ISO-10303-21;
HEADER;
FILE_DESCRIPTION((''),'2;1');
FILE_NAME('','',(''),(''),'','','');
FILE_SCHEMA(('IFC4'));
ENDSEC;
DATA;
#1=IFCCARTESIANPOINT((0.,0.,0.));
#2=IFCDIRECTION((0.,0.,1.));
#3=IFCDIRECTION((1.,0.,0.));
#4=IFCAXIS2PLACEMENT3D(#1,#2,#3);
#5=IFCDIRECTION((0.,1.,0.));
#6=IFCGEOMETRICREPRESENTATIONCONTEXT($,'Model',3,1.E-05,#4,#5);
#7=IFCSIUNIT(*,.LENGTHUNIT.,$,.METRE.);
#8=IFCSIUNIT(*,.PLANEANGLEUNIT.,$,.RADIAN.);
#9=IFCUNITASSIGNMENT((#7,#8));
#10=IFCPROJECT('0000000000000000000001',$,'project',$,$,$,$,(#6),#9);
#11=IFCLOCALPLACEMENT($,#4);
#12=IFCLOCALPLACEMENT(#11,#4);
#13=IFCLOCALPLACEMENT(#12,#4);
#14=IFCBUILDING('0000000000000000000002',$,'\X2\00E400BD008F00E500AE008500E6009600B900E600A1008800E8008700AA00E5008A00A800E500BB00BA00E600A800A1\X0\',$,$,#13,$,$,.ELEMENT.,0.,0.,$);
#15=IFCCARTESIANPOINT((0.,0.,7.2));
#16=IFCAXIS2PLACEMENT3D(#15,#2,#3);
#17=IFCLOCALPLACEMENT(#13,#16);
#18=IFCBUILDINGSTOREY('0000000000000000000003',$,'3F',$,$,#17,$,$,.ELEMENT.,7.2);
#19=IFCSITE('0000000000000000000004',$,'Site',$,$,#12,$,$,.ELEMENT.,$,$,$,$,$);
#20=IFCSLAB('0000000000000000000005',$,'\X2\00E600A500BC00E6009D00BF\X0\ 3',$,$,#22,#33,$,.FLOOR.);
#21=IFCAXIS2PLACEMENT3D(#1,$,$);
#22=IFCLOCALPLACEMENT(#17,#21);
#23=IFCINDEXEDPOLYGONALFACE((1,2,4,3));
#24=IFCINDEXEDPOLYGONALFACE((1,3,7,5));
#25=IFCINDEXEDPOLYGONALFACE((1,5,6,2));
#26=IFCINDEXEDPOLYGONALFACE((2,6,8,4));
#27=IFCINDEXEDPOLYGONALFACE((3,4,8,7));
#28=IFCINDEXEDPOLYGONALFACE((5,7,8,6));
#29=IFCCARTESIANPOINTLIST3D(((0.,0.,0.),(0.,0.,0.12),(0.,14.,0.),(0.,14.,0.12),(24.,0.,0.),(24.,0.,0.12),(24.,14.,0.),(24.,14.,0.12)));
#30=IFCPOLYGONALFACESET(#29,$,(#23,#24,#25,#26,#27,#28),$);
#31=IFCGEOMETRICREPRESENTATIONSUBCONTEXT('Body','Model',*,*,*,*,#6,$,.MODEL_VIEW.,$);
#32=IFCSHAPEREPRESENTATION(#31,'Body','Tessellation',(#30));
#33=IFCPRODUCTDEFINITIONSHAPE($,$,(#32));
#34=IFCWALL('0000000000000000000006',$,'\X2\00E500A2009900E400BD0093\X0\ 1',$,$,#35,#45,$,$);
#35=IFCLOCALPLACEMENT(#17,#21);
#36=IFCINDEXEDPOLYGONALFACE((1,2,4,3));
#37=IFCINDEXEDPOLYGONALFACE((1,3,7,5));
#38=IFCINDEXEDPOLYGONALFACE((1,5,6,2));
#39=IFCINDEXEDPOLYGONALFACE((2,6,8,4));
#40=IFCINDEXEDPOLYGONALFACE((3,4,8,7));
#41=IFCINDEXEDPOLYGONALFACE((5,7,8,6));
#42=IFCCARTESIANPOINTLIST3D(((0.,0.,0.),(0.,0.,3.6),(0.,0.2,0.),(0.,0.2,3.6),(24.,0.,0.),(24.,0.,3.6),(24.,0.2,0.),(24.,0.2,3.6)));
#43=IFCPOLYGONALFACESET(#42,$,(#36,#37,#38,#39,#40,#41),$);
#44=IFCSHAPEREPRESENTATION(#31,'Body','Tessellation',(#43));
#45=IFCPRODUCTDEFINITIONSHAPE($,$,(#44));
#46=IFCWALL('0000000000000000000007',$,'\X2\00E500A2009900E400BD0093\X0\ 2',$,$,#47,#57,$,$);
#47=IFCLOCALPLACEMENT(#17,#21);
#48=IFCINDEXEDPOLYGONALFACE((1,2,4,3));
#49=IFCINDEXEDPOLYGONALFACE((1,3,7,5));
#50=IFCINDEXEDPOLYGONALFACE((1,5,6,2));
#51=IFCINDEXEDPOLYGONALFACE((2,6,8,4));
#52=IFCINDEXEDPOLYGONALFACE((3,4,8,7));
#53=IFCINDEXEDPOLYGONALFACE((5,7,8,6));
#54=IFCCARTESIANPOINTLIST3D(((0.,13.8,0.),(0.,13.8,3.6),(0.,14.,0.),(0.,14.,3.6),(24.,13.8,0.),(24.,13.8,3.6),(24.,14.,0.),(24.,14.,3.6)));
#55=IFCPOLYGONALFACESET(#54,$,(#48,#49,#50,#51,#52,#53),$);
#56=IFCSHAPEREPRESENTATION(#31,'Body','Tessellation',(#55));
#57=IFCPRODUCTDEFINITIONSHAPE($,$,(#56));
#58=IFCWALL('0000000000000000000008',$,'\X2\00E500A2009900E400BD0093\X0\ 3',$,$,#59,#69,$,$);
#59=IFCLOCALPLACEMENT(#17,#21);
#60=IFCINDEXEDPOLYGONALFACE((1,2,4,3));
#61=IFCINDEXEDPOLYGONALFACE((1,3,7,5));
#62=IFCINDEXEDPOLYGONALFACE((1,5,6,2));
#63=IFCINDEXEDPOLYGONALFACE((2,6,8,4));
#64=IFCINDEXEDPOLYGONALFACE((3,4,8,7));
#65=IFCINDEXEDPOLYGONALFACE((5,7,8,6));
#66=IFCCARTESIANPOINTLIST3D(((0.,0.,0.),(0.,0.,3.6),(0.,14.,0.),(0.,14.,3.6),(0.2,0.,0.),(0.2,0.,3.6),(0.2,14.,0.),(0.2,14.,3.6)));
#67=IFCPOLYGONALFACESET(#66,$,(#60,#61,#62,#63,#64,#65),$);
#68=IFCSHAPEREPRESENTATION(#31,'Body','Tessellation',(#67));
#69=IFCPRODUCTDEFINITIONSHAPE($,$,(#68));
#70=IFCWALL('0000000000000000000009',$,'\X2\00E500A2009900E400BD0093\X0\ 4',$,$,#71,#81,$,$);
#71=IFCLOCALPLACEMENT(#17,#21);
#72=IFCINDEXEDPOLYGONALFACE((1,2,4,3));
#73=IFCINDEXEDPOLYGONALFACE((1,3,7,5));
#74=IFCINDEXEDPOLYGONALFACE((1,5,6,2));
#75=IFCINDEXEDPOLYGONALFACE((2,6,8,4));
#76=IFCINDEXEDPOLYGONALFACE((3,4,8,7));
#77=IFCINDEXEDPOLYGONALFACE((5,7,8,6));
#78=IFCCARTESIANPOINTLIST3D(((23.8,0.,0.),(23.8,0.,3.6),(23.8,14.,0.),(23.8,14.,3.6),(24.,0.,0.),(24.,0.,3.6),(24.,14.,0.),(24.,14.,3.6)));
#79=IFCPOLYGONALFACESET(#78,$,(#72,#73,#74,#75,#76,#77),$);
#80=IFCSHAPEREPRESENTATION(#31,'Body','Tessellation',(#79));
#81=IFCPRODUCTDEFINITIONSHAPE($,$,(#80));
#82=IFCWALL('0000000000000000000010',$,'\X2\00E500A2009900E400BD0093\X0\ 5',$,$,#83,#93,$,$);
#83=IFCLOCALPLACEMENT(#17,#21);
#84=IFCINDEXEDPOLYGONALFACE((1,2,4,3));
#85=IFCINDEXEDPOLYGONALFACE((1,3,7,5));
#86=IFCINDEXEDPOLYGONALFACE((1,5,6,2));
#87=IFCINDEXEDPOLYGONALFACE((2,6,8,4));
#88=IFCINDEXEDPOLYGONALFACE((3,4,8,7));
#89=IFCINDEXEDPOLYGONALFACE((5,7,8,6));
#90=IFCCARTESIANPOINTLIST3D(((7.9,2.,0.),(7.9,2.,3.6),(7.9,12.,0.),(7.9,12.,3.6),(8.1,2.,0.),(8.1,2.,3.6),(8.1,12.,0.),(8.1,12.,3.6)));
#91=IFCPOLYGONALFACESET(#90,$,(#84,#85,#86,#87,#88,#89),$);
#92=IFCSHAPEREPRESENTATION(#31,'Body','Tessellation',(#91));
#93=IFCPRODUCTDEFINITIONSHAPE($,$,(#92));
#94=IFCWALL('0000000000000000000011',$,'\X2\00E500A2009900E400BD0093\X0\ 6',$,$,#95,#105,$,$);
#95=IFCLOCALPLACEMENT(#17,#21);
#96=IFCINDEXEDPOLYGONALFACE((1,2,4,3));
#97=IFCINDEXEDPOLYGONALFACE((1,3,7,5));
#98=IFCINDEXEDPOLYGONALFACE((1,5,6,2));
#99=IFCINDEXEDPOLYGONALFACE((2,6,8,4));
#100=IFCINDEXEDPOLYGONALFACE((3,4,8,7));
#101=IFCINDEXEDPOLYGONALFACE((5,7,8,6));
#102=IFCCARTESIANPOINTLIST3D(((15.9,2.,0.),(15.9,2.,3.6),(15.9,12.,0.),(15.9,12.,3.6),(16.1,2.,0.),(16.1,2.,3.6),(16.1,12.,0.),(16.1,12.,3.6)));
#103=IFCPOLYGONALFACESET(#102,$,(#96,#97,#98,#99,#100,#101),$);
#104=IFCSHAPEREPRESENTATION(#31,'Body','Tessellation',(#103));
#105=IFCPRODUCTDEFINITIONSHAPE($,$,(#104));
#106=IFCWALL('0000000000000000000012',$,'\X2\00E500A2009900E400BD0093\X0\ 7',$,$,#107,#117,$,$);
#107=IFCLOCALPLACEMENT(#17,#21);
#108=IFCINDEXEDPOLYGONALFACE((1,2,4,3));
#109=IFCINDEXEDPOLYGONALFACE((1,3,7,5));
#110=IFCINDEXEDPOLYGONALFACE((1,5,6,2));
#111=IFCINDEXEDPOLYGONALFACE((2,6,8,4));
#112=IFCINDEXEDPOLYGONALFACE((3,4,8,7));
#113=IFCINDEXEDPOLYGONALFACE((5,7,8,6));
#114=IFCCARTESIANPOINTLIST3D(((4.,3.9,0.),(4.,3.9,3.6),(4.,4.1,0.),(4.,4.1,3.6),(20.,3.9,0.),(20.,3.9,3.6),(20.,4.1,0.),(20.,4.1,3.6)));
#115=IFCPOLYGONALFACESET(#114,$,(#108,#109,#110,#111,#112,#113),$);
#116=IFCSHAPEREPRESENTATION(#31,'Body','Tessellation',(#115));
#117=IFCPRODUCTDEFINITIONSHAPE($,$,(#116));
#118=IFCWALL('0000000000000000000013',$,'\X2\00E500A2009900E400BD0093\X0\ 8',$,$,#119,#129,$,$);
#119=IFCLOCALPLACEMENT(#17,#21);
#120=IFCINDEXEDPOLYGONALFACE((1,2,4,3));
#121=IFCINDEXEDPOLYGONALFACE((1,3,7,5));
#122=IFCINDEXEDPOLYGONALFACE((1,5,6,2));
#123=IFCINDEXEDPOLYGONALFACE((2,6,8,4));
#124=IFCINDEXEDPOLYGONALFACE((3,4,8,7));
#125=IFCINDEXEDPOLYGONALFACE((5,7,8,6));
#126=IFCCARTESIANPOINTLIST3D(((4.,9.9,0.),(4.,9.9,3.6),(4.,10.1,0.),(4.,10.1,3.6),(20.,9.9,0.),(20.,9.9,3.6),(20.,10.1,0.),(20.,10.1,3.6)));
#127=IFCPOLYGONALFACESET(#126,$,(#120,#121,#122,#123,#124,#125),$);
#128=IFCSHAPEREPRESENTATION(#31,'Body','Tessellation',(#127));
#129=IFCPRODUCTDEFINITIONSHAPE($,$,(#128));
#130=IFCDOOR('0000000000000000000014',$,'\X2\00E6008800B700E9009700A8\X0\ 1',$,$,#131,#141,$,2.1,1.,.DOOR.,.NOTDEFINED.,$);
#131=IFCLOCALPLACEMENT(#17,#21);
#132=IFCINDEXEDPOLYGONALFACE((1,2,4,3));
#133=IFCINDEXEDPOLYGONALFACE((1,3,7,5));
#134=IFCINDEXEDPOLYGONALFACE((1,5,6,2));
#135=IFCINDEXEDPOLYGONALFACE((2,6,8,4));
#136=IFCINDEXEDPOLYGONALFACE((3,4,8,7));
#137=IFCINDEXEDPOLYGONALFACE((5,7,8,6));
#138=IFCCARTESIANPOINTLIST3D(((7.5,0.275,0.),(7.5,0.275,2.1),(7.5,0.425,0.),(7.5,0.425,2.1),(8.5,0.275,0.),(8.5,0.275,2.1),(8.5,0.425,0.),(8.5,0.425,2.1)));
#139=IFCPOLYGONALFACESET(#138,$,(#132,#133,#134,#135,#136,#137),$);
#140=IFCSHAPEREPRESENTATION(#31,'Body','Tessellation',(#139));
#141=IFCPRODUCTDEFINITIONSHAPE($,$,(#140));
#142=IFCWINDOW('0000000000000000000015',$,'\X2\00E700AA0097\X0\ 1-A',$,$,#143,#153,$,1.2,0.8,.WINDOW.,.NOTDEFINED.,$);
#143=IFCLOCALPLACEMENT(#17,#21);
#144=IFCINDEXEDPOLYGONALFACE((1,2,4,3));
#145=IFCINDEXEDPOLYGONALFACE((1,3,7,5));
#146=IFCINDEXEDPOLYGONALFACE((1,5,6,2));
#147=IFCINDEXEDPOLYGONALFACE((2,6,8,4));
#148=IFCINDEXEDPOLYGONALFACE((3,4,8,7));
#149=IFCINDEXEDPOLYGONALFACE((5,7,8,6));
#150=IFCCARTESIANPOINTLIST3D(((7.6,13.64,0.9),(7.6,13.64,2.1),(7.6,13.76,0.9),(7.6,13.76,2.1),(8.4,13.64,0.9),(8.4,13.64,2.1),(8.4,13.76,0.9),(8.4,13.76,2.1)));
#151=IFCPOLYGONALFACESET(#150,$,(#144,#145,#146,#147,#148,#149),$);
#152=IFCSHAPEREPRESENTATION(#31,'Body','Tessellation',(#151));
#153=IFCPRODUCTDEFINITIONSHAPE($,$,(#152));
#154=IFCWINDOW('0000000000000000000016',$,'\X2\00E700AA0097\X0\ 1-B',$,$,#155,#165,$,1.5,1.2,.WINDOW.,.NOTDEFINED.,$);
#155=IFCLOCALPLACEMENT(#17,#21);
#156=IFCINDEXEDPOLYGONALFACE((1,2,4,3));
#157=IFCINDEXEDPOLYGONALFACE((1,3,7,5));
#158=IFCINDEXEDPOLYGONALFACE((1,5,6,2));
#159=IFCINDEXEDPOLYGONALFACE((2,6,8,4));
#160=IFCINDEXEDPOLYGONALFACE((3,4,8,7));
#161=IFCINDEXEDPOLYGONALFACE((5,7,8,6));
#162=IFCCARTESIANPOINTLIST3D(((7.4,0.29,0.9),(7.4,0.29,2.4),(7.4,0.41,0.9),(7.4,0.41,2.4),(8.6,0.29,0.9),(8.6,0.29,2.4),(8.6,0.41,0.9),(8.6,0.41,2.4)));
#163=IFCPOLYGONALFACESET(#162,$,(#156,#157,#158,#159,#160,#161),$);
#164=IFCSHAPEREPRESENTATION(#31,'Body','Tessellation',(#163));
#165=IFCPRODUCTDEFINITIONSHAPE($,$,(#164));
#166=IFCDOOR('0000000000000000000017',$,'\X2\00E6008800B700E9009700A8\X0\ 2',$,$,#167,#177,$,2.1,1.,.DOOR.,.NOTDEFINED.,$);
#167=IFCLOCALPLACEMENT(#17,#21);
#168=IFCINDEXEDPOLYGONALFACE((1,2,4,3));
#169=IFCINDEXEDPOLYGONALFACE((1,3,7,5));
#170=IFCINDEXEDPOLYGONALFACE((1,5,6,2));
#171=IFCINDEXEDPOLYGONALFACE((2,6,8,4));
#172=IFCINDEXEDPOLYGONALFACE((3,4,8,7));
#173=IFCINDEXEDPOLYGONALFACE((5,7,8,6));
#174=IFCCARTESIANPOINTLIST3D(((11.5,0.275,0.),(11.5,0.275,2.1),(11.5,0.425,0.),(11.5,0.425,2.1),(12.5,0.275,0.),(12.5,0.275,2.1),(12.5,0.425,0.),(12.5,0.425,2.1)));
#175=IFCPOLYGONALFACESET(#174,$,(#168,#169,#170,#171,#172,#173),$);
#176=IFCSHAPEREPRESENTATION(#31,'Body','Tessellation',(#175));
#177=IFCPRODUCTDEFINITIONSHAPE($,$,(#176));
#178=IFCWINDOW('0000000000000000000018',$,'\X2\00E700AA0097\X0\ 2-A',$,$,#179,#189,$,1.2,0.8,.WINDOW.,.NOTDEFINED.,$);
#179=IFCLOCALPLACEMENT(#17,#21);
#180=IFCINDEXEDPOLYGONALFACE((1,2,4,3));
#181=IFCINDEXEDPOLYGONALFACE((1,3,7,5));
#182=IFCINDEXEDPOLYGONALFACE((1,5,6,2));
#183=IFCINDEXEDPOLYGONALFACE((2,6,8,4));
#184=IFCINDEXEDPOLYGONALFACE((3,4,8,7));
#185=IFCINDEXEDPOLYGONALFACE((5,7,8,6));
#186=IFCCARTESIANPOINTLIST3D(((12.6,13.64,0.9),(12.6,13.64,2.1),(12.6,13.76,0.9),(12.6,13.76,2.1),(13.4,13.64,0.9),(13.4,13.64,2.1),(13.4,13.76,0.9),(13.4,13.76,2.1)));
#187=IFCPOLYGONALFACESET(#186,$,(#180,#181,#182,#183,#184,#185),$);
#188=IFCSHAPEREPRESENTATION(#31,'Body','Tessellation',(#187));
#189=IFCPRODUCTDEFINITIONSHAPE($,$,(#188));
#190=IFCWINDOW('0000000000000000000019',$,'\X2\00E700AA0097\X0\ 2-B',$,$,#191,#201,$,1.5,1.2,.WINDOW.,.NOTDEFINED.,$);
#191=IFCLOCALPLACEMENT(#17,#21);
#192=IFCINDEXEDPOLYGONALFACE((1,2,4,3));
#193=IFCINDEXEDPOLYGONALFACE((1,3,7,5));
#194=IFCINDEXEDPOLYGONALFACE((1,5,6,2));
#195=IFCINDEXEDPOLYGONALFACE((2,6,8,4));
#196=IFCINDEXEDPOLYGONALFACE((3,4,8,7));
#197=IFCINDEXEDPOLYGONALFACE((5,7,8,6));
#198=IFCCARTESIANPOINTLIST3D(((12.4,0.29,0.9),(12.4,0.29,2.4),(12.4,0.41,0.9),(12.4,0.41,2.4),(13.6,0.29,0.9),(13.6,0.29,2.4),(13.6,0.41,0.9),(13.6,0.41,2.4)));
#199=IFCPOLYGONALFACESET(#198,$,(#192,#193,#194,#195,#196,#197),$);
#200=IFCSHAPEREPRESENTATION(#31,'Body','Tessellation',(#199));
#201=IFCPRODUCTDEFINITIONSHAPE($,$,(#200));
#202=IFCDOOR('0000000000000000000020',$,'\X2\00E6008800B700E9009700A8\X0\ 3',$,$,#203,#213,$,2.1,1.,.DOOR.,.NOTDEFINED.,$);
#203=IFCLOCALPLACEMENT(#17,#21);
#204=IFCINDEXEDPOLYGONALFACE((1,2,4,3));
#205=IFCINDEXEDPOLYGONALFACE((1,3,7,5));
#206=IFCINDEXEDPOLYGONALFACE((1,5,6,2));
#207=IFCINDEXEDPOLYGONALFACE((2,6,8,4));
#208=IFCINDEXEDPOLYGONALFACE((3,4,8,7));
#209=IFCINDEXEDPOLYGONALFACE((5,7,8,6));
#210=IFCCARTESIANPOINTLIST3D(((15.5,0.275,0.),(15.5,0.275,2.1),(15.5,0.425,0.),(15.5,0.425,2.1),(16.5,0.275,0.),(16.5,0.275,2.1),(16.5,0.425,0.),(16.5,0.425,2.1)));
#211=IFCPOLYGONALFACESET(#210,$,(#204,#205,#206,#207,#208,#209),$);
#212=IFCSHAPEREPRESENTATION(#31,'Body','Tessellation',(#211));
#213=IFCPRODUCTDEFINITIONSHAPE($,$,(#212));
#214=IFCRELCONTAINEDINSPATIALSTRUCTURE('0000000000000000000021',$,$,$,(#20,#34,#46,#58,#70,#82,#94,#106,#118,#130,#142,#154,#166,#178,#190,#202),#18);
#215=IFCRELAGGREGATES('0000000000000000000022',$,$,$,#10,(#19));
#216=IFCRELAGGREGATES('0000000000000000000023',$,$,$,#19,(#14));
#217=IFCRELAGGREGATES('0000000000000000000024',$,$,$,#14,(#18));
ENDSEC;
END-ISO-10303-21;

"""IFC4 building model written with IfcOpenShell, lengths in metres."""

from ifc_helpers import new_model, si_unit, direction, frame, frame_2d, origin_with_axes, place, context, subcontext, project, spatial, rectangle, extrude, element, save


model = new_model("IFC4")

# Units and contexts
model_context = context("Model", 3, precision=1e-05, world=origin_with_axes(), true_north=direction((0.0, 1.0, 0.0)))
body_context = subcontext(model_context, "Body", "Model", "MODEL_VIEW")
ifc_project = project(units=[si_unit("LENGTHUNIT", "METRE"), si_unit("PLANEANGLEUNIT", "RADIAN")], contexts=[model_context])

# Site, building, storey
placement = place(None, origin_with_axes())
site_placement = place(placement, origin_with_axes())
site = spatial("IfcSite", under=ifc_project, at=site_placement, Name="Site", CompositionType="ELEMENT")
building_placement = place(site_placement, origin_with_axes())
building = spatial("IfcBuilding", under=site, at=building_placement, Name="ä½\u008få®\u0085æ\u0096¹æ¡\u0088è\u0087ªå\u008a¨å»ºæ¨¡", CompositionType="ELEMENT", ElevationOfRefHeight=0.0, ElevationOfTerrain=0.0)
storey_placement = place(building_placement, frame((0.0, 0.0, 7.2), z_axis=(0.0, 0.0, 1.0), x_axis=(1.0, 0.0, 0.0)))
storey = spatial("IfcBuildingStorey", under=building, at=storey_placement, Name="3F", CompositionType="ELEMENT", Elevation=7.2)

# Slab
slab_placement = place(storey_placement, frame((12.0, 7.0, 0.0), z_axis=(0.0, 0.0, 1.0), x_axis=(1.0, 0.0, 0.0)))
element("IfcSlab", 1, at=slab_placement, inside=storey, Name="æ¥¼æ\u009d¿ 3", PredefinedType="FLOOR", context=body_context, shape_type="SweptSolid", body=[
    extrude(rectangle(XDim=24.0, YDim=14.0, at=frame_2d((0.0, 0.0), x_axis=(1.0, 0.0, 0.0))), frame((0.0, 0.0, 0.0), z_axis=(0.0, 0.0, 1.0)), (0.0, 0.0, 1.0), 0.12),
])

# Walls
for number, where, z_axis, x_axis, name in (
    (2, (12.0, 0.1, 0.0), (0.0, 0.0, 1.0), (1.0, 0.0, 0.0), "å¢\u0099ä½\u0093 1"),
    (3, (12.0, 13.9, 0.0), (0.0, 0.0, 1.0), (1.0, 0.0, 0.0), "å¢\u0099ä½\u0093 2"),
):
    element("IfcWall", number, at=place(storey_placement, frame(where, z_axis=z_axis, x_axis=x_axis)), inside=storey, Name=name, context=body_context, shape_type="SweptSolid", body=[
        extrude(rectangle(XDim=24.0, YDim=0.2, at=frame_2d((0.0, 0.0), x_axis=(1.0, 0.0, 0.0))), frame((0.0, 0.0, 0.0), z_axis=(0.0, 0.0, 1.0)), (0.0, 0.0, 1.0), 3.6),
    ])
for number, where, z_axis, x_axis, name in (
    (4, (0.1, 7.0, 0.0), (0.0, 0.0, 1.0), (0.0, 1.0, 0.0), "å¢\u0099ä½\u0093 3"),
    (5, (23.9, 7.0, 0.0), (0.0, 0.0, 1.0), (0.0, 1.0, 0.0), "å¢\u0099ä½\u0093 4"),
):
    element("IfcWall", number, at=place(storey_placement, frame(where, z_axis=z_axis, x_axis=x_axis)), inside=storey, Name=name, context=body_context, shape_type="SweptSolid", body=[
        extrude(rectangle(XDim=14.0, YDim=0.2, at=frame_2d((0.0, 0.0), x_axis=(1.0, 0.0, 0.0))), frame((0.0, 0.0, 0.0), z_axis=(0.0, 0.0, 1.0)), (0.0, 0.0, 1.0), 3.6),
    ])
for number, where, z_axis, x_axis, name in (
    (6, (8.0, 7.0, 0.0), (0.0, 0.0, 1.0), (0.0, 1.0, 0.0), "å¢\u0099ä½\u0093 5"),
    (7, (16.0, 7.0, 0.0), (0.0, 0.0, 1.0), (0.0, 1.0, 0.0), "å¢\u0099ä½\u0093 6"),
):
    element("IfcWall", number, at=place(storey_placement, frame(where, z_axis=z_axis, x_axis=x_axis)), inside=storey, Name=name, context=body_context, shape_type="SweptSolid", body=[
        extrude(rectangle(XDim=10.0, YDim=0.2, at=frame_2d((0.0, 0.0), x_axis=(1.0, 0.0, 0.0))), frame((0.0, 0.0, 0.0), z_axis=(0.0, 0.0, 1.0)), (0.0, 0.0, 1.0), 3.6),
    ])
for number, where, z_axis, x_axis, name in (
    (8, (12.0, 4.0, 0.0), (0.0, 0.0, 1.0), (1.0, 0.0, 0.0), "å¢\u0099ä½\u0093 7"),
    (9, (12.0, 10.0, 0.0), (0.0, 0.0, 1.0), (1.0, 0.0, 0.0), "å¢\u0099ä½\u0093 8"),
):
    element("IfcWall", number, at=place(storey_placement, frame(where, z_axis=z_axis, x_axis=x_axis)), inside=storey, Name=name, context=body_context, shape_type="SweptSolid", body=[
        extrude(rectangle(XDim=16.0, YDim=0.2, at=frame_2d((0.0, 0.0), x_axis=(1.0, 0.0, 0.0))), frame((0.0, 0.0, 0.0), z_axis=(0.0, 0.0, 1.0)), (0.0, 0.0, 1.0), 3.6),
    ])

# Door
door_1_placement = place(storey_placement, frame((8.0, 0.35, 0.0), z_axis=(0.0, 0.0, 1.0), x_axis=(1.0, 0.0, 0.0)))
element("IfcDoor", 10, at=door_1_placement, inside=storey, Name="æ\u0088·é\u0097¨ 1", OperationType="NOTDEFINED", OverallHeight=2.1, OverallWidth=1.0, PredefinedType="DOOR", context=body_context, shape_type="SweptSolid", body=[
    extrude(rectangle(XDim=1.0, YDim=0.15, at=frame_2d((0.0, 0.0), x_axis=(1.0, 0.0, 0.0))), frame((0.0, 0.0, 0.0), z_axis=(0.0, 0.0, 1.0)), (0.0, 0.0, 1.0), 2.1),
])

# Windows
window_1_placement = place(storey_placement, frame((8.0, 13.7, 0.9), z_axis=(0.0, 0.0, 1.0), x_axis=(1.0, 0.0, 0.0)))
element("IfcWindow", 11, at=window_1_placement, inside=storey, Name="çª\u0097 1-A", OverallHeight=1.2, OverallWidth=0.8, PartitioningType="NOTDEFINED", PredefinedType="WINDOW", context=body_context, shape_type="SweptSolid", body=[
    extrude(rectangle(XDim=0.8, YDim=0.12, at=frame_2d((0.0, 0.0), x_axis=(1.0, 0.0, 0.0))), frame((0.0, 0.0, 0.0), z_axis=(0.0, 0.0, 1.0)), (0.0, 0.0, 1.0), 1.2),
])
window_2_placement = place(storey_placement, frame((8.0, 0.35, 0.9), z_axis=(0.0, 0.0, 1.0), x_axis=(1.0, 0.0, 0.0)))
element("IfcWindow", 12, at=window_2_placement, inside=storey, Name="çª\u0097 1-B", OverallHeight=1.5, OverallWidth=1.2, PartitioningType="NOTDEFINED", PredefinedType="WINDOW", context=body_context, shape_type="SweptSolid", body=[
    extrude(rectangle(XDim=1.2, YDim=0.12, at=frame_2d((0.0, 0.0), x_axis=(1.0, 0.0, 0.0))), frame((0.0, 0.0, 0.0), z_axis=(0.0, 0.0, 1.0)), (0.0, 0.0, 1.0), 1.5),
])

# Door
door_2_placement = place(storey_placement, frame((12.0, 0.35, 0.0), z_axis=(0.0, 0.0, 1.0), x_axis=(1.0, 0.0, 0.0)))
element("IfcDoor", 13, at=door_2_placement, inside=storey, Name="æ\u0088·é\u0097¨ 2", OperationType="NOTDEFINED", OverallHeight=2.1, OverallWidth=1.0, PredefinedType="DOOR", context=body_context, shape_type="SweptSolid", body=[
    extrude(rectangle(XDim=1.0, YDim=0.15, at=frame_2d((0.0, 0.0), x_axis=(1.0, 0.0, 0.0))), frame((0.0, 0.0, 0.0), z_axis=(0.0, 0.0, 1.0)), (0.0, 0.0, 1.0), 2.1),
])

# Windows
window_3_placement = place(storey_placement, frame((13.0, 13.7, 0.9), z_axis=(0.0, 0.0, 1.0), x_axis=(1.0, 0.0, 0.0)))
element("IfcWindow", 14, at=window_3_placement, inside=storey, Name="çª\u0097 2-A", OverallHeight=1.2, OverallWidth=0.8, PartitioningType="NOTDEFINED", PredefinedType="WINDOW", context=body_context, shape_type="SweptSolid", body=[
    extrude(rectangle(XDim=0.8, YDim=0.12, at=frame_2d((0.0, 0.0), x_axis=(1.0, 0.0, 0.0))), frame((0.0, 0.0, 0.0), z_axis=(0.0, 0.0, 1.0)), (0.0, 0.0, 1.0), 1.2),
])
window_4_placement = place(storey_placement, frame((13.0, 0.35, 0.9), z_axis=(0.0, 0.0, 1.0), x_axis=(1.0, 0.0, 0.0)))
element("IfcWindow", 15, at=window_4_placement, inside=storey, Name="çª\u0097 2-B", OverallHeight=1.5, OverallWidth=1.2, PartitioningType="NOTDEFINED", PredefinedType="WINDOW", context=body_context, shape_type="SweptSolid", body=[
    extrude(rectangle(XDim=1.2, YDim=0.12, at=frame_2d((0.0, 0.0), x_axis=(1.0, 0.0, 0.0))), frame((0.0, 0.0, 0.0), z_axis=(0.0, 0.0, 1.0)), (0.0, 0.0, 1.0), 1.5),
])

# Door
door_3_placement = place(storey_placement, frame((16.0, 0.35, 0.0), z_axis=(0.0, 0.0, 1.0), x_axis=(1.0, 0.0, 0.0)))
element("IfcDoor", 16, at=door_3_placement, inside=storey, Name="æ\u0088·é\u0097¨ 3", OperationType="NOTDEFINED", OverallHeight=2.1, OverallWidth=1.0, PredefinedType="DOOR", context=body_context, shape_type="SweptSolid", body=[
    extrude(rectangle(XDim=1.0, YDim=0.15, at=frame_2d((0.0, 0.0), x_axis=(1.0, 0.0, 0.0))), frame((0.0, 0.0, 0.0), z_axis=(0.0, 0.0, 1.0)), (0.0, 0.0, 1.0), 2.1),
])

save(model, "model.ifc")
